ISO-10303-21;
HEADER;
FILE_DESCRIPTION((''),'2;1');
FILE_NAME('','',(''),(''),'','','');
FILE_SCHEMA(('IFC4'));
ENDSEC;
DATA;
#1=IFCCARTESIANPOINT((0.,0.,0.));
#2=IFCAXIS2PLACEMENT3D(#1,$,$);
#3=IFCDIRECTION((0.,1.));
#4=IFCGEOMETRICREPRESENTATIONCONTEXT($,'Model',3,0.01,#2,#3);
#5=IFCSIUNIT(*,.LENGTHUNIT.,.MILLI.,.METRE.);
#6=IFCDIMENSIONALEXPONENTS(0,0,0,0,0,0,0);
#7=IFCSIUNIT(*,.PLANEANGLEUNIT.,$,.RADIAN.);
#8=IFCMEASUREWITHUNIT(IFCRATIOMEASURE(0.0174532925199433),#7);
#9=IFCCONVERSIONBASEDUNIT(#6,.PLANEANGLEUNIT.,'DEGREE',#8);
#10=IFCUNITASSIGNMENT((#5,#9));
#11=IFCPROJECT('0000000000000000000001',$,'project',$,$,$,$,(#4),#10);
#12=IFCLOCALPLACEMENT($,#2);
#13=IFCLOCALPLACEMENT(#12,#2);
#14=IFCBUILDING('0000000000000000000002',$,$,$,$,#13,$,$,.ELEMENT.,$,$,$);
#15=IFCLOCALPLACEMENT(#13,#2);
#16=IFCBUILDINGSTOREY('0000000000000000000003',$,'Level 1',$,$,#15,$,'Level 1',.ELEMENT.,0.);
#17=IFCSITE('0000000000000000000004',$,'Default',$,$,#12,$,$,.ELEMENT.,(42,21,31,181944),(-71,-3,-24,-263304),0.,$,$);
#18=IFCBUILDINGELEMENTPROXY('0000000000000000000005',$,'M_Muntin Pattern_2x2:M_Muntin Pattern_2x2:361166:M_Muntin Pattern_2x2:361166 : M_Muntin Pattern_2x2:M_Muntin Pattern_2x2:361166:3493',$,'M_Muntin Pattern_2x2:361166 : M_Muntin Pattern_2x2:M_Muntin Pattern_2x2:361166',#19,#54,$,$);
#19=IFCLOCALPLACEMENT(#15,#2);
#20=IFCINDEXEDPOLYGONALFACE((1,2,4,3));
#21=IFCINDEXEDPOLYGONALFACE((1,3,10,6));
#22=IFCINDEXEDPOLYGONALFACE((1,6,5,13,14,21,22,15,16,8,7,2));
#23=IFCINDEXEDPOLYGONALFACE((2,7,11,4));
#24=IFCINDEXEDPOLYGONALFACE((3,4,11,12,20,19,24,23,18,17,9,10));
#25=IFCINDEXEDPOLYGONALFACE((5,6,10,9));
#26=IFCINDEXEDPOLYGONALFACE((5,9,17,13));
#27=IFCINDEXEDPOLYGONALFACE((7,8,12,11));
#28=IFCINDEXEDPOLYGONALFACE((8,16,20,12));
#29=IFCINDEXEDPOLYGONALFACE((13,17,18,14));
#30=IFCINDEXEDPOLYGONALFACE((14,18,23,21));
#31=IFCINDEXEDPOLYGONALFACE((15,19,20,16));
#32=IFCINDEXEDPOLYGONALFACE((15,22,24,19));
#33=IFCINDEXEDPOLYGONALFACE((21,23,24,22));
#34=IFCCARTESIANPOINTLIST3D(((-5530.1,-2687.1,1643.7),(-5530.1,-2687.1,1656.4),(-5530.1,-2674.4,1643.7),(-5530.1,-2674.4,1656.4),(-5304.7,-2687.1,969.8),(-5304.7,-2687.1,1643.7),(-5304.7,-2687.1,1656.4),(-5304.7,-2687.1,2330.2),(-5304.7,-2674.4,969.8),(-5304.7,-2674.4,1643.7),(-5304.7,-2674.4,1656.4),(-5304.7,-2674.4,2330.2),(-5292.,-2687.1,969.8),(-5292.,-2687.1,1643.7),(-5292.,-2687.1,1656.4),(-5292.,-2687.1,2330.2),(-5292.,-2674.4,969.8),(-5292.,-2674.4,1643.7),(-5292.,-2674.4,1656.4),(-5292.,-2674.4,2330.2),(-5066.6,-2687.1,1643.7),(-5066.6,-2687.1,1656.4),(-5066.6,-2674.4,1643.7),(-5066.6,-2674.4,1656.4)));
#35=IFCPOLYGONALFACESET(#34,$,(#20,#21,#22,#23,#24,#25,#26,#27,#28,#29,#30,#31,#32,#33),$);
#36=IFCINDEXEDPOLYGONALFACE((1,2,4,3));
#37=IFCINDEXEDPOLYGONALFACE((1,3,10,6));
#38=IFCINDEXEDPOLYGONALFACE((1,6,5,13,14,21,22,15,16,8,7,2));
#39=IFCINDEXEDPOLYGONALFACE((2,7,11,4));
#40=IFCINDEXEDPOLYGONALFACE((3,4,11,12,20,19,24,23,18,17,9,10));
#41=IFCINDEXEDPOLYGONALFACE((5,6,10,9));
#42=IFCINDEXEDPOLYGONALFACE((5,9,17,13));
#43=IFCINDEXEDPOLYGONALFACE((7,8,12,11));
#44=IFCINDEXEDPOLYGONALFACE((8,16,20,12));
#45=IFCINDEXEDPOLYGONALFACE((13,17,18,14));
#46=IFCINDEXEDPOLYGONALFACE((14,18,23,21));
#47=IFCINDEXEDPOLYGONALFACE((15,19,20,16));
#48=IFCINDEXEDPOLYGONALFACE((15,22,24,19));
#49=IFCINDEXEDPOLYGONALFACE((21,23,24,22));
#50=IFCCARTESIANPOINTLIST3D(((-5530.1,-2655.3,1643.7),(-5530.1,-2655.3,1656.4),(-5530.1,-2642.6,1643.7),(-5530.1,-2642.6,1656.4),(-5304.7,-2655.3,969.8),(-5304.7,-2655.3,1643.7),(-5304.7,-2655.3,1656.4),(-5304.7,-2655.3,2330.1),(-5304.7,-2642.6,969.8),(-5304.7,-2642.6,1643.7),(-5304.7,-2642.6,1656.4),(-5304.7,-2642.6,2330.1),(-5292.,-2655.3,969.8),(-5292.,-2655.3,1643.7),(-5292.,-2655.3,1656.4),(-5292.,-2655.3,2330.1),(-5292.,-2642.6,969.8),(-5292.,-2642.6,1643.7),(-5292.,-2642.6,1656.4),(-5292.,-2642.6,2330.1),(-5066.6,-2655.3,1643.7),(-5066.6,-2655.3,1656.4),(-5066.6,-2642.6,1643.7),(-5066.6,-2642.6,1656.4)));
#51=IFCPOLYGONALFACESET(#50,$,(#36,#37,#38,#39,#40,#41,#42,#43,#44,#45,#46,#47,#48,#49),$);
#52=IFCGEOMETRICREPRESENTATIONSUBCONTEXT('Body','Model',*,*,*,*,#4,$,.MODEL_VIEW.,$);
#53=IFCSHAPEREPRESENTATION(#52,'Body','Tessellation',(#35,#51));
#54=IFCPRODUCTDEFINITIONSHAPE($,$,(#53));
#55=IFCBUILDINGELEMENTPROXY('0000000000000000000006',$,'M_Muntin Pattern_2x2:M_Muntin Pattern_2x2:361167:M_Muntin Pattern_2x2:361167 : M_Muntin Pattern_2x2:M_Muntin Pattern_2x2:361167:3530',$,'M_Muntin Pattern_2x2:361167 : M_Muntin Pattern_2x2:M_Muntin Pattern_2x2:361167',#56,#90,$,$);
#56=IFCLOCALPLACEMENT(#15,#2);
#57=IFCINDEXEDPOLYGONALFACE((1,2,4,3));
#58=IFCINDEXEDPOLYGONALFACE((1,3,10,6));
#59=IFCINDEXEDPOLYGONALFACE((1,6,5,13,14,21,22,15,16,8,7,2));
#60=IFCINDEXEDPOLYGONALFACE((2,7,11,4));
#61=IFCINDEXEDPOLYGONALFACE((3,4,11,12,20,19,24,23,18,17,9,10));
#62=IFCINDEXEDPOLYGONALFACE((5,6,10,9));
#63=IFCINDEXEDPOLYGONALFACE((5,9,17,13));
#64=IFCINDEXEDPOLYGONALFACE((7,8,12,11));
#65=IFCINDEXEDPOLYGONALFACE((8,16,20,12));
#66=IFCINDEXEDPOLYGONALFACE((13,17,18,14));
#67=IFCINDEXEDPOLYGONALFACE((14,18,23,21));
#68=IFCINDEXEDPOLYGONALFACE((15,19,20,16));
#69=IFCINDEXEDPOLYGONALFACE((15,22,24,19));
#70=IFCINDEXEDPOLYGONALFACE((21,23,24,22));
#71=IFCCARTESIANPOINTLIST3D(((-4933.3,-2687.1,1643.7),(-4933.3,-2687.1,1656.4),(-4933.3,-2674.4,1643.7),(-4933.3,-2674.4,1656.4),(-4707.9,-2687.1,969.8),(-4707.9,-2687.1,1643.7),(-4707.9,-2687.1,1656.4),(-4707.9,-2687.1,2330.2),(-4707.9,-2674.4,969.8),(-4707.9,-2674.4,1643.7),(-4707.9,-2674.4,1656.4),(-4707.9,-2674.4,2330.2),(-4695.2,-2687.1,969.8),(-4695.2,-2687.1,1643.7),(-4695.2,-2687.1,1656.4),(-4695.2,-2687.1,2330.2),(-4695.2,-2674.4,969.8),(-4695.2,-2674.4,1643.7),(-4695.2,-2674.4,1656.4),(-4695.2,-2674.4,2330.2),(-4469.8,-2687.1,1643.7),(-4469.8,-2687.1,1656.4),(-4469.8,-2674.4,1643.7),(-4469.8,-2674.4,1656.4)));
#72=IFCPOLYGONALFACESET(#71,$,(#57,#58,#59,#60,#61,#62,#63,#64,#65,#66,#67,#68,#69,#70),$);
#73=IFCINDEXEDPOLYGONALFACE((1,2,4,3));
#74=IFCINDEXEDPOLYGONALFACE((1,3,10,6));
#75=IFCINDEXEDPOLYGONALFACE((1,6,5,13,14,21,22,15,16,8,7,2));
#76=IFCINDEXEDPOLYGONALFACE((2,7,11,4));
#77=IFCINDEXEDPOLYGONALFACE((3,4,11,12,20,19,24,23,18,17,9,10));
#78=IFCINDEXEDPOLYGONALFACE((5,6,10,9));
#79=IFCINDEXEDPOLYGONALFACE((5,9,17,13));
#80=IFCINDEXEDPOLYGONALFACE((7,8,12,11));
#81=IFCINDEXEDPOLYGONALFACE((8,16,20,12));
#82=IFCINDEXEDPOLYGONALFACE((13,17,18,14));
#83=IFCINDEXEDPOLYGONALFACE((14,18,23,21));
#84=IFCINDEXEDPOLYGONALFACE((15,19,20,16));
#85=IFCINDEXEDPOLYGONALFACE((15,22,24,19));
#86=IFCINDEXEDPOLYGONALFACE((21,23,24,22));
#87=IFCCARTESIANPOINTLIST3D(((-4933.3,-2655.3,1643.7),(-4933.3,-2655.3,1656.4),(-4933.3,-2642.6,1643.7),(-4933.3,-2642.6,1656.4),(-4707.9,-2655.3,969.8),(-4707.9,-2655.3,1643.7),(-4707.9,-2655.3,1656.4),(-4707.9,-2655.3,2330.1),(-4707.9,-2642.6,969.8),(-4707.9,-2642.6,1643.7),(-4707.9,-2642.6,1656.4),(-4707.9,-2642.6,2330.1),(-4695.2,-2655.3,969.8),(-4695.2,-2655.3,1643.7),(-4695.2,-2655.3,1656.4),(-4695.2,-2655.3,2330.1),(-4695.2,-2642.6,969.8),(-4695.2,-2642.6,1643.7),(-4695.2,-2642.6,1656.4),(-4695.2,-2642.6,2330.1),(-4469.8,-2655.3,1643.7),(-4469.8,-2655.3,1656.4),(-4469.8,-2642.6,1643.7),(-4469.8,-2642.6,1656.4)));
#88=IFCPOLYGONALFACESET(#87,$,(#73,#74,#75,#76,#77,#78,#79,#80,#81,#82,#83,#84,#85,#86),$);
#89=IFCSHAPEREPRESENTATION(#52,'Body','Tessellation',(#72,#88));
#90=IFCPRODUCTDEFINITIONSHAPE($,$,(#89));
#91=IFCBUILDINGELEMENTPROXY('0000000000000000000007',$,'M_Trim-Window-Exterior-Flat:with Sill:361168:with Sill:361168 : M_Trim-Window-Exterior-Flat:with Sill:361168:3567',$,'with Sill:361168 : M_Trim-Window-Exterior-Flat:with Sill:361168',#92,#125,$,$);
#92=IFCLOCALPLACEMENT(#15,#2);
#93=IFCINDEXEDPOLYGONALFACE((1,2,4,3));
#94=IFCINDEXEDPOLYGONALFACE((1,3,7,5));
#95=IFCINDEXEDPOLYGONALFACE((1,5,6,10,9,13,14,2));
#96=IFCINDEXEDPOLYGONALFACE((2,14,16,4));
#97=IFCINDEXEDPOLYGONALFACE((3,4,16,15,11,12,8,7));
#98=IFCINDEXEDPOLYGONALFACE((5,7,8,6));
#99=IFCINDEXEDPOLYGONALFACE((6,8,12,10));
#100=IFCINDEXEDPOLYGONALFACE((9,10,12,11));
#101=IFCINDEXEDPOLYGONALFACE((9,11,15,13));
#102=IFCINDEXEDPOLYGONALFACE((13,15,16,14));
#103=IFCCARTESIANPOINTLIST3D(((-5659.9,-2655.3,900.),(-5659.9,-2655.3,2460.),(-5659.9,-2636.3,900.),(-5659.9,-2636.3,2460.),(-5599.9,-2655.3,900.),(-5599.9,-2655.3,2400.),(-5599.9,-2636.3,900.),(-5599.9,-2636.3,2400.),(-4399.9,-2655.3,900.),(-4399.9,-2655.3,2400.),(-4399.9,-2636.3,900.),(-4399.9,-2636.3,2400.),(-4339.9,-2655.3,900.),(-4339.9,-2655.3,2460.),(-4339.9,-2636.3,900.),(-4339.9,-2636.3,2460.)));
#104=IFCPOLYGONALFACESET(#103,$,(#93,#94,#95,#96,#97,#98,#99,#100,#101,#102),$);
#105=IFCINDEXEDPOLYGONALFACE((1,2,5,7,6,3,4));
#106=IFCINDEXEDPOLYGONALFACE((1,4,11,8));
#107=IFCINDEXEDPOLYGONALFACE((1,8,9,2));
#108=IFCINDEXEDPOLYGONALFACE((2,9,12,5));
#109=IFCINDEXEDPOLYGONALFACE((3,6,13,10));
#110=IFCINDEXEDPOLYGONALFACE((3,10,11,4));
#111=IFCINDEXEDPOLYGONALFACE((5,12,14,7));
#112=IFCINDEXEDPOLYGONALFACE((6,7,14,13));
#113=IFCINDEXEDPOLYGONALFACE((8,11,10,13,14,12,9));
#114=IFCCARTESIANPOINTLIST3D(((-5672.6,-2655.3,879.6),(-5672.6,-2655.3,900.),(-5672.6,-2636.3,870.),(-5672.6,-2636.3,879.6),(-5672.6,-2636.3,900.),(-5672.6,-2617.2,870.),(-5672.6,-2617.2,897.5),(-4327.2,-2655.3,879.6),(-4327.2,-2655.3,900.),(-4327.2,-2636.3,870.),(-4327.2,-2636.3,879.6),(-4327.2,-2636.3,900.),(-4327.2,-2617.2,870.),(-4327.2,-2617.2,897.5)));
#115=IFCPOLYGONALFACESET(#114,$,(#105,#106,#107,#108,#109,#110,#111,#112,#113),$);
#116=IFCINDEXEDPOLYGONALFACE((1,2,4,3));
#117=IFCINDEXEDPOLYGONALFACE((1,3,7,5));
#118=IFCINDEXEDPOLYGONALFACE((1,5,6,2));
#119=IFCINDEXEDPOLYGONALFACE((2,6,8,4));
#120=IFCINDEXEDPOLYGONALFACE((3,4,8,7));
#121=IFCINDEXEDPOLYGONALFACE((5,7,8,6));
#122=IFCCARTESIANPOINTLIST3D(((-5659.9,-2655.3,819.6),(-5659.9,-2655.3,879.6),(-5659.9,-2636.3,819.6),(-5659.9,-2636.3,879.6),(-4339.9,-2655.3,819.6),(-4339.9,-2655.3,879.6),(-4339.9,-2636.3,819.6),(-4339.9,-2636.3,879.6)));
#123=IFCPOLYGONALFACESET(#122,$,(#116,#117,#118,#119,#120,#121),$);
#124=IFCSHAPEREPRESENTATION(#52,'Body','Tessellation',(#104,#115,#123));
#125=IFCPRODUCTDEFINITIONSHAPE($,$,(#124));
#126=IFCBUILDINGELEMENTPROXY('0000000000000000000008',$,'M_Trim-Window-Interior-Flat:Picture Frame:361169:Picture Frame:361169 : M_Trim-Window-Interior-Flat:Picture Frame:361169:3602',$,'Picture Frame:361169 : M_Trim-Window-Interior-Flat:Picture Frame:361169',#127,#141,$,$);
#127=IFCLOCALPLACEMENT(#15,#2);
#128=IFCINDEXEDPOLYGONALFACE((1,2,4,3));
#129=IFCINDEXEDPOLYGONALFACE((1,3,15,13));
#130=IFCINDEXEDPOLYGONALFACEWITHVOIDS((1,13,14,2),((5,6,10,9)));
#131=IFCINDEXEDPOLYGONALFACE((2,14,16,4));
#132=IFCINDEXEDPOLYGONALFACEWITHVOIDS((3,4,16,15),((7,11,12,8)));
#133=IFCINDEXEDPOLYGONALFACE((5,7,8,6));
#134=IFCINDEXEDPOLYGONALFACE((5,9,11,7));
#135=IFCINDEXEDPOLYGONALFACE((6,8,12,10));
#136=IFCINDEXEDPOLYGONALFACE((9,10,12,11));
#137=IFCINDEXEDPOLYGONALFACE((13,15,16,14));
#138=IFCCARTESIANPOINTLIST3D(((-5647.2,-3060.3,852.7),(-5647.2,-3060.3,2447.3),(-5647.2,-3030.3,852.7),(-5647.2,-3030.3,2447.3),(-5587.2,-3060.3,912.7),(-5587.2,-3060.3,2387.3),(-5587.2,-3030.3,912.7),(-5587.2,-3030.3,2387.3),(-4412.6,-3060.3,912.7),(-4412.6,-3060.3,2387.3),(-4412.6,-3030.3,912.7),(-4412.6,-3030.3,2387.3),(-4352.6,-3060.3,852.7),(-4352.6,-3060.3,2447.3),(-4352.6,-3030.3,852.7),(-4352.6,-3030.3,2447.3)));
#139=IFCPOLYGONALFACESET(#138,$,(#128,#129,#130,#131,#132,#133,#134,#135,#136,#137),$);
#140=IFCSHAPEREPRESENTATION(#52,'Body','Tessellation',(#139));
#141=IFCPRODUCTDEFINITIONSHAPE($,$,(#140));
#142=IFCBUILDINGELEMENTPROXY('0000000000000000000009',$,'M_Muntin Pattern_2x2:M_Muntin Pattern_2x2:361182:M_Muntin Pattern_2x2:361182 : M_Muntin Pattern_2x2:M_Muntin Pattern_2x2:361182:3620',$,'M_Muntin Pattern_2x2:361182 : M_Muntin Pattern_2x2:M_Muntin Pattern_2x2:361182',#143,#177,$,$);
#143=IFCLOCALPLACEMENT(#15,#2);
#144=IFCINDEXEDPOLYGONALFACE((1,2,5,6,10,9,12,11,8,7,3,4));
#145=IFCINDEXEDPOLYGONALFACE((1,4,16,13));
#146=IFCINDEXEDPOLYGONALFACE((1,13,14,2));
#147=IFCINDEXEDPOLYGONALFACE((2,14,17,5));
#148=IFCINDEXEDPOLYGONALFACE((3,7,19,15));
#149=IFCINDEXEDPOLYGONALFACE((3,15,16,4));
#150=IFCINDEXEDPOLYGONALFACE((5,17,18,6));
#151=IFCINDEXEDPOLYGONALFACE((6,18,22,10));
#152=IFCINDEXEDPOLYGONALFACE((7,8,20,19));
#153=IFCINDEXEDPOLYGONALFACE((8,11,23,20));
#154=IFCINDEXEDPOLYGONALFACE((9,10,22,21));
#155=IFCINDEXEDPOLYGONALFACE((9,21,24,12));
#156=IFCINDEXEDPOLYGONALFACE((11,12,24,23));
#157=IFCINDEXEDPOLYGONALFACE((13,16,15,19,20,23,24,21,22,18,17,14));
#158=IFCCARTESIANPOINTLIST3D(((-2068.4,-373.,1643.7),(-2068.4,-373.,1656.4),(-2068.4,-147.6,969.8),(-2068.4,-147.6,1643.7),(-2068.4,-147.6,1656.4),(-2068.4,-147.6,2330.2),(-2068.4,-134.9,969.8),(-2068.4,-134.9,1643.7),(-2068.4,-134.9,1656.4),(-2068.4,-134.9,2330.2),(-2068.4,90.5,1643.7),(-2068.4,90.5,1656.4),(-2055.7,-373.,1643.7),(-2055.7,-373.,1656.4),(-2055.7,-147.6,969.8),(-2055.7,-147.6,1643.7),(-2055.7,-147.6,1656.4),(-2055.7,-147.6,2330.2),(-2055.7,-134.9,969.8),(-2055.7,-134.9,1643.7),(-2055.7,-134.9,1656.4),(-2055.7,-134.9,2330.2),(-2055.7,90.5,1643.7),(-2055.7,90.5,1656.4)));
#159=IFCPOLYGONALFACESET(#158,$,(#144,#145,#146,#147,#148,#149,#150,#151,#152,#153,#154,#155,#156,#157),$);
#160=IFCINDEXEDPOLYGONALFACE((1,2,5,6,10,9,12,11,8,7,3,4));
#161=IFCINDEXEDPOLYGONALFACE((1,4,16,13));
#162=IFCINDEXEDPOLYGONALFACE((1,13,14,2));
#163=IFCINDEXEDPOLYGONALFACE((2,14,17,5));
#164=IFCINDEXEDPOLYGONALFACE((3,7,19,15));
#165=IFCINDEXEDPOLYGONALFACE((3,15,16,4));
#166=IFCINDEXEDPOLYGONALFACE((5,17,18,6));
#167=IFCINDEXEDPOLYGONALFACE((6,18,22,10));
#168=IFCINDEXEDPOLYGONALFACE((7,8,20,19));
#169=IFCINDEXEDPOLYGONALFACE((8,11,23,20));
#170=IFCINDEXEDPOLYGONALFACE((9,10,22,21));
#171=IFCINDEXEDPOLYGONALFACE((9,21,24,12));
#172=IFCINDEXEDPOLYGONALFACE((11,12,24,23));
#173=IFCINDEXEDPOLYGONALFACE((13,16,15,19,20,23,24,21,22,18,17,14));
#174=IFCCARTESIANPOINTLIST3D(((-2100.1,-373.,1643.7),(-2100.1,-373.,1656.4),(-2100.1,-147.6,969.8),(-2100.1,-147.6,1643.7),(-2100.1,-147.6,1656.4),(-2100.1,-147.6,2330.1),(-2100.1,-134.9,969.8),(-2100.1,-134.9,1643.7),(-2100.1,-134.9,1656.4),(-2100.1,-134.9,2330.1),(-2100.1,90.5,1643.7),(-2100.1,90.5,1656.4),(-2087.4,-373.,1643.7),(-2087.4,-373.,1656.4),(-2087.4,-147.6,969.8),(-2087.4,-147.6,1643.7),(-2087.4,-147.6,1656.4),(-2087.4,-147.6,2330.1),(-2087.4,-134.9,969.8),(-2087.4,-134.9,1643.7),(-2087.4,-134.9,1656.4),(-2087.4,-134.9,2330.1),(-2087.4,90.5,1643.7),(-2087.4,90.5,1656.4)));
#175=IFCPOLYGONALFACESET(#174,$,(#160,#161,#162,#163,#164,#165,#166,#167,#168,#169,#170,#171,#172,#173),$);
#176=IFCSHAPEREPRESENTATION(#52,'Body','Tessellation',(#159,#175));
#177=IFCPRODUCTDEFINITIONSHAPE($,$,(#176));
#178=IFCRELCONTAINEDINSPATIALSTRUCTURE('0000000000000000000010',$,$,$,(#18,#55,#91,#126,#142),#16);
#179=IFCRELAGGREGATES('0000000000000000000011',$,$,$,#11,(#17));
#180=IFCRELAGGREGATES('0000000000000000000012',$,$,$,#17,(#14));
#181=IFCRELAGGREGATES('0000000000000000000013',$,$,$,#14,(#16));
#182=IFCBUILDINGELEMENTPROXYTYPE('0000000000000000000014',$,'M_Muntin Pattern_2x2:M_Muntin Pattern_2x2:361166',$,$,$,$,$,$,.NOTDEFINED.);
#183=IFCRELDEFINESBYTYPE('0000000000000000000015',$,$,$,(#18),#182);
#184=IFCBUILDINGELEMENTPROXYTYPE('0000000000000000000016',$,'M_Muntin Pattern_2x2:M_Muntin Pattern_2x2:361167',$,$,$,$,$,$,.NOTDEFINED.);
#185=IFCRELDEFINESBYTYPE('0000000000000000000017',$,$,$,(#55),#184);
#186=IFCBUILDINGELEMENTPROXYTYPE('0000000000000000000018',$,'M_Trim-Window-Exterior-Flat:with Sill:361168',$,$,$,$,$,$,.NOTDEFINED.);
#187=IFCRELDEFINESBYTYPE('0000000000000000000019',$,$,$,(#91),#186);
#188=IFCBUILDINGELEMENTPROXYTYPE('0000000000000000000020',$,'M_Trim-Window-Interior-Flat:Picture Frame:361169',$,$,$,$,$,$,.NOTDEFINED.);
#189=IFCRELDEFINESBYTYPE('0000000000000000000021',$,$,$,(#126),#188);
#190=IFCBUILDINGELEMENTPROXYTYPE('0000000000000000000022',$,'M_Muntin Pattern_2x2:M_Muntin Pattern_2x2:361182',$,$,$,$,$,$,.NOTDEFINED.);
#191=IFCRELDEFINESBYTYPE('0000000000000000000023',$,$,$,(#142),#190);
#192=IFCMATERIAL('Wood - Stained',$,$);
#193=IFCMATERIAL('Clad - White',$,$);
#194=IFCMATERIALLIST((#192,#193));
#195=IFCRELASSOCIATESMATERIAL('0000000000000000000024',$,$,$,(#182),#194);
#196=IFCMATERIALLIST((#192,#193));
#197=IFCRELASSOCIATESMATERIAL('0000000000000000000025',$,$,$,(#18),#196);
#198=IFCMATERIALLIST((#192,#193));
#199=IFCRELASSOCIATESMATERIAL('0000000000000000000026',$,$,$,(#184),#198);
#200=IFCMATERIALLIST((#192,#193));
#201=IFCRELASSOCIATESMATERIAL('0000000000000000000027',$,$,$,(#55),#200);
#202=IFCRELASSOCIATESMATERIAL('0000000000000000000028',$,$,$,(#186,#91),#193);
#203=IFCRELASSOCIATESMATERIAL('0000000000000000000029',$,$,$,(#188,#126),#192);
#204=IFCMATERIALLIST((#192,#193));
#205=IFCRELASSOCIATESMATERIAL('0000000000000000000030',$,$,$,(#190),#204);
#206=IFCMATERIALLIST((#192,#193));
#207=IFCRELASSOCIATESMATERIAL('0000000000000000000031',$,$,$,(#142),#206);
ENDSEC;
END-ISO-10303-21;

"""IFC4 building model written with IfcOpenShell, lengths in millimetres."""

from ifc_helpers import new_model, entity, si_unit, converted_unit, direction, frame, frame_2d, origin, place, context, subcontext, project, spatial, polyline, rectangle, outline, extrude, source, transform, mapped, material, material_list, type_object, type_shapes, element, save


model = new_model("IFC4")

# Units and contexts
model_context = context("Model", 3, precision=0.01, world=origin(), true_north=direction((0.0, 1.0)))
body_context = subcontext(model_context, "Body", "Model", "MODEL_VIEW")
ifc_project = project(units=[si_unit("LENGTHUNIT", "METRE", prefix="MILLI"), converted_unit("PLANEANGLEUNIT", "DEGREE", entity("IfcRatioMeasure", 0.0174532925199433), si_unit("PLANEANGLEUNIT", "RADIAN"), dimensions=[0, 0, 0, 0, 0, 0, 0])], contexts=[model_context])

# Site, building, storey
site_placement = place(None, origin())
site = spatial("IfcSite", under=ifc_project, at=site_placement, Name="Default", CompositionType="ELEMENT", RefLatitude=(42, 21, 31, 181944), RefLongitude=(-71, -3, -24, -263304), RefElevation=0.0)
building_placement = place(site_placement, origin())
building = spatial("IfcBuilding", under=site, at=building_placement, CompositionType="ELEMENT")
storey_placement = place(building_placement, origin())
storey = spatial("IfcBuildingStorey", under=building, at=storey_placement, Name="Level 1", LongName="Level 1", CompositionType="ELEMENT", Elevation=0.0)

# Building element proxies
ifc_material_1 = material(Name="Wood - Stained")
ifc_material_2 = material(Name="Clad - White")
ifc_material_list_1 = material_list([ifc_material_1, ifc_material_2])
ifc_material_list_2 = material_list([ifc_material_1, ifc_material_2])
building_element_proxy_type_1 = type_object("IfcBuildingElementProxyType", Name="M_Muntin Pattern_2x2:M_Muntin Pattern_2x2:361166", PredefinedType="NOTDEFINED", material=ifc_material_list_2)
shared_shape_1 = source(origin(), body_context, "Body", "SweptSolid", [
    extrude(outline(polyline([(-6.4, -680.2), (6.3, -680.2), (6.3, -6.4), (231.7, -6.4), (231.7, 6.3), (6.3, 6.3), (6.3, 680.2), (-6.4, 680.2), (-6.4, 6.3), (-231.7, 6.3), (-231.7, -6.4), (-6.4, -6.4), (-6.4, -680.2)])), frame((-5298.4, -2687.1, 1650.0), z_axis=(0.0, 1.0, 0.0), x_axis=(1.0, 0.0, 0.0)), (0.0, 0.0, 1.0), 12.7),
    extrude(outline(polyline([(-6.4, -680.1), (6.3, -680.1), (6.3, -6.4), (231.7, -6.4), (231.7, 6.3), (6.3, 6.3), (6.3, 680.2), (-6.4, 680.2), (-6.4, 6.3), (-231.7, 6.3), (-231.7, -6.4), (-6.4, -6.4), (-6.4, -680.1)])), frame((-5298.4, -2655.3, 1650.0), z_axis=(0.0, 1.0, 0.0), x_axis=(1.0, 0.0, 0.0)), (0.0, 0.0, 1.0), 12.7),
])
type_shapes(building_element_proxy_type_1, [shared_shape_1])
proxy_1_placement = place(storey_placement, origin())
element("IfcBuildingElementProxy", 1, at=proxy_1_placement, inside=storey, type_object=building_element_proxy_type_1, material=ifc_material_list_1, Name="M_Muntin Pattern_2x2:M_Muntin Pattern_2x2:361166:M_Muntin Pattern_2x2:361166 : M_Muntin Pattern_2x2:M_Muntin Pattern_2x2:361166:3493", ObjectType="M_Muntin Pattern_2x2:361166 : M_Muntin Pattern_2x2:M_Muntin Pattern_2x2:361166", context=body_context, shape_type="MappedRepresentation", body=[
    mapped(shared_shape_1, transform((0.0, 0.0, 0.0), scale=1.0)),
])
ifc_material_list_3 = material_list([ifc_material_1, ifc_material_2])
ifc_material_list_4 = material_list([ifc_material_1, ifc_material_2])
building_element_proxy_type_2 = type_object("IfcBuildingElementProxyType", Name="M_Muntin Pattern_2x2:M_Muntin Pattern_2x2:361167", PredefinedType="NOTDEFINED", material=ifc_material_list_4)
shared_shape_2 = source(origin(), body_context, "Body", "SweptSolid", [
    extrude(outline(polyline([(-680.1, 6.4), (-680.1, -6.3), (-6.4, -6.3), (-6.4, -231.7), (6.3, -231.7), (6.3, -6.3), (680.2, -6.3), (680.2, 6.4), (6.3, 6.4), (6.3, 231.7), (-6.4, 231.7), (-6.4, 6.4), (-680.1, 6.4)])), frame((-4701.5, -2687.1, 1650.0), z_axis=(0.0, -1.0, 0.0), x_axis=(0.0, 0.0, -1.0)), (0.0, 0.0, -1.0), 12.7),
    extrude(outline(polyline([(-680.1, 6.4), (-680.1, -6.3), (-6.4, -6.3), (-6.4, -231.7), (6.3, -231.7), (6.3, -6.3), (680.2, -6.3), (680.2, 6.4), (6.3, 6.4), (6.3, 231.7), (-6.4, 231.7), (-6.4, 6.4), (-680.1, 6.4)])), frame((-4701.5, -2655.3, 1650.0), z_axis=(0.0, -1.0, 0.0), x_axis=(0.0, 0.0, -1.0)), (0.0, 0.0, -1.0), 12.7),
])
type_shapes(building_element_proxy_type_2, [shared_shape_2])
proxy_2_placement = place(storey_placement, origin())
element("IfcBuildingElementProxy", 2, at=proxy_2_placement, inside=storey, type_object=building_element_proxy_type_2, material=ifc_material_list_3, Name="M_Muntin Pattern_2x2:M_Muntin Pattern_2x2:361167:M_Muntin Pattern_2x2:361167 : M_Muntin Pattern_2x2:M_Muntin Pattern_2x2:361167:3530", ObjectType="M_Muntin Pattern_2x2:361167 : M_Muntin Pattern_2x2:M_Muntin Pattern_2x2:361167", context=body_context, shape_type="MappedRepresentation", body=[
    mapped(shared_shape_2, transform((0.0, 0.0, 0.0), scale=1.0)),
])
building_element_proxy_type_3 = type_object("IfcBuildingElementProxyType", Name="M_Trim-Window-Exterior-Flat:with Sill:361168", PredefinedType="NOTDEFINED", material=ifc_material_2)
shared_shape_3 = source(origin(), body_context, "Body", "SweptSolid", [
    extrude(outline(polyline([(-660.0, -765.0), (-600.0, -765.0), (-600.0, 735.0), (600.0, 735.0), (600.0, -765.0), (660.0, -765.0), (660.0, 795.0), (-660.0, 795.0), (-660.0, -765.0)])), frame((-4999.9, -2655.3, 1665.0), z_axis=(0.0, 1.0, 0.0), x_axis=(-1.0, 0.0, 0.0)), (0.0, 0.0, 1.0), 19.1),
    extrude(outline(polyline([(0.0, -15.2), (19.0, -15.2), (19.0, 12.3), (0.0, 14.8), (-19.0, 14.8), (-19.0, -5.7), (0.0, -5.7), (0.0, -15.2)])), frame((-5672.6, -2636.3, 885.2), z_axis=(1.0, 0.0, 0.0), x_axis=(0.0, 1.0, 0.0)), (0.0, 0.0, 1.0), 1345.4),
    extrude(rectangle(XDim=19.1, YDim=1320.0, at=frame_2d((0.0, 0.0), x_axis=(1.0, 0.0))), frame((-4999.9, -2645.8, 819.6), z_axis=(0.0, 0.0, 1.0), x_axis=(0.0, -1.0, 0.0)), (0.0, 0.0, 1.0), 60.0),
])
type_shapes(building_element_proxy_type_3, [shared_shape_3])
proxy_3_placement = place(storey_placement, origin())
element("IfcBuildingElementProxy", 3, at=proxy_3_placement, inside=storey, type_object=building_element_proxy_type_3, material=ifc_material_2, Name="M_Trim-Window-Exterior-Flat:with Sill:361168:with Sill:361168 : M_Trim-Window-Exterior-Flat:with Sill:361168:3567", ObjectType="with Sill:361168 : M_Trim-Window-Exterior-Flat:with Sill:361168", context=body_context, shape_type="MappedRepresentation", body=[
    mapped(shared_shape_3, transform((0.0, 0.0, 0.0), scale=1.0)),
])
building_element_proxy_type_4 = type_object("IfcBuildingElementProxyType", Name="M_Trim-Window-Interior-Flat:Picture Frame:361169", PredefinedType="NOTDEFINED", material=ifc_material_1)
shared_shape_4 = source(origin(), body_context, "Body", "SweptSolid", [
    extrude(outline(polyline([(-647.3, -797.3), (647.3, -797.3), (647.3, 797.3), (-647.3, 797.3), (-647.3, -797.3)]), holes=[polyline([(587.3, 737.3), (587.3, -737.3), (-587.3, -737.3), (-587.3, 737.3), (587.3, 737.3)])]), frame((-4999.9, -3060.3, 1650.0), z_axis=(0.0, 1.0, 0.0), x_axis=(1.0, 0.0, 0.0)), (0.0, 0.0, 1.0), 30.0),
])
type_shapes(building_element_proxy_type_4, [shared_shape_4])
proxy_4_placement = place(storey_placement, origin())
element("IfcBuildingElementProxy", 4, at=proxy_4_placement, inside=storey, type_object=building_element_proxy_type_4, material=ifc_material_1, Name="M_Trim-Window-Interior-Flat:Picture Frame:361169:Picture Frame:361169 : M_Trim-Window-Interior-Flat:Picture Frame:361169:3602", ObjectType="Picture Frame:361169 : M_Trim-Window-Interior-Flat:Picture Frame:361169", context=body_context, shape_type="MappedRepresentation", body=[
    mapped(shared_shape_4, transform((0.0, 0.0, 0.0), scale=1.0)),
])
ifc_material_list_5 = material_list([ifc_material_1, ifc_material_2])
ifc_material_list_6 = material_list([ifc_material_1, ifc_material_2])
building_element_proxy_type_5 = type_object("IfcBuildingElementProxyType", Name="M_Muntin Pattern_2x2:M_Muntin Pattern_2x2:361182", PredefinedType="NOTDEFINED", material=ifc_material_list_6)
shared_shape_5 = source(origin(), body_context, "Body", "SweptSolid", [
    extrude(outline(polyline([(-680.2, 6.4), (-680.2, -6.3), (-6.4, -6.3), (-6.4, -231.7), (6.3, -231.7), (6.3, -6.3), (680.2, -6.3), (680.2, 6.4), (6.3, 6.4), (6.3, 231.7), (-6.4, 231.7), (-6.4, 6.4), (-680.2, 6.4)])), frame((-2068.4, -141.3, 1650.0), z_axis=(-1.0, 0.0, 0.0), x_axis=(0.0, 0.0, -1.0)), (0.0, 0.0, -1.0), 12.7),
    extrude(outline(polyline([(-680.1, 6.4), (-680.1, -6.3), (-6.4, -6.3), (-6.4, -231.7), (6.3, -231.7), (6.3, -6.3), (680.2, -6.3), (680.2, 6.4), (6.3, 6.4), (6.3, 231.7), (-6.4, 231.7), (-6.4, 6.4), (-680.1, 6.4)])), frame((-2100.1, -141.3, 1650.0), z_axis=(-1.0, 0.0, 0.0), x_axis=(0.0, 0.0, -1.0)), (0.0, 0.0, -1.0), 12.7),
])
type_shapes(building_element_proxy_type_5, [shared_shape_5])
proxy_5_placement = place(storey_placement, origin())
element("IfcBuildingElementProxy", 5, at=proxy_5_placement, inside=storey, type_object=building_element_proxy_type_5, material=ifc_material_list_5, Name="M_Muntin Pattern_2x2:M_Muntin Pattern_2x2:361182:M_Muntin Pattern_2x2:361182 : M_Muntin Pattern_2x2:M_Muntin Pattern_2x2:361182:3620", ObjectType="M_Muntin Pattern_2x2:361182 : M_Muntin Pattern_2x2:M_Muntin Pattern_2x2:361182", context=body_context, shape_type="MappedRepresentation", body=[
    mapped(shared_shape_5, transform((0.0, 0.0, 0.0), scale=1.0)),
])

save(model, "model.ifc")
